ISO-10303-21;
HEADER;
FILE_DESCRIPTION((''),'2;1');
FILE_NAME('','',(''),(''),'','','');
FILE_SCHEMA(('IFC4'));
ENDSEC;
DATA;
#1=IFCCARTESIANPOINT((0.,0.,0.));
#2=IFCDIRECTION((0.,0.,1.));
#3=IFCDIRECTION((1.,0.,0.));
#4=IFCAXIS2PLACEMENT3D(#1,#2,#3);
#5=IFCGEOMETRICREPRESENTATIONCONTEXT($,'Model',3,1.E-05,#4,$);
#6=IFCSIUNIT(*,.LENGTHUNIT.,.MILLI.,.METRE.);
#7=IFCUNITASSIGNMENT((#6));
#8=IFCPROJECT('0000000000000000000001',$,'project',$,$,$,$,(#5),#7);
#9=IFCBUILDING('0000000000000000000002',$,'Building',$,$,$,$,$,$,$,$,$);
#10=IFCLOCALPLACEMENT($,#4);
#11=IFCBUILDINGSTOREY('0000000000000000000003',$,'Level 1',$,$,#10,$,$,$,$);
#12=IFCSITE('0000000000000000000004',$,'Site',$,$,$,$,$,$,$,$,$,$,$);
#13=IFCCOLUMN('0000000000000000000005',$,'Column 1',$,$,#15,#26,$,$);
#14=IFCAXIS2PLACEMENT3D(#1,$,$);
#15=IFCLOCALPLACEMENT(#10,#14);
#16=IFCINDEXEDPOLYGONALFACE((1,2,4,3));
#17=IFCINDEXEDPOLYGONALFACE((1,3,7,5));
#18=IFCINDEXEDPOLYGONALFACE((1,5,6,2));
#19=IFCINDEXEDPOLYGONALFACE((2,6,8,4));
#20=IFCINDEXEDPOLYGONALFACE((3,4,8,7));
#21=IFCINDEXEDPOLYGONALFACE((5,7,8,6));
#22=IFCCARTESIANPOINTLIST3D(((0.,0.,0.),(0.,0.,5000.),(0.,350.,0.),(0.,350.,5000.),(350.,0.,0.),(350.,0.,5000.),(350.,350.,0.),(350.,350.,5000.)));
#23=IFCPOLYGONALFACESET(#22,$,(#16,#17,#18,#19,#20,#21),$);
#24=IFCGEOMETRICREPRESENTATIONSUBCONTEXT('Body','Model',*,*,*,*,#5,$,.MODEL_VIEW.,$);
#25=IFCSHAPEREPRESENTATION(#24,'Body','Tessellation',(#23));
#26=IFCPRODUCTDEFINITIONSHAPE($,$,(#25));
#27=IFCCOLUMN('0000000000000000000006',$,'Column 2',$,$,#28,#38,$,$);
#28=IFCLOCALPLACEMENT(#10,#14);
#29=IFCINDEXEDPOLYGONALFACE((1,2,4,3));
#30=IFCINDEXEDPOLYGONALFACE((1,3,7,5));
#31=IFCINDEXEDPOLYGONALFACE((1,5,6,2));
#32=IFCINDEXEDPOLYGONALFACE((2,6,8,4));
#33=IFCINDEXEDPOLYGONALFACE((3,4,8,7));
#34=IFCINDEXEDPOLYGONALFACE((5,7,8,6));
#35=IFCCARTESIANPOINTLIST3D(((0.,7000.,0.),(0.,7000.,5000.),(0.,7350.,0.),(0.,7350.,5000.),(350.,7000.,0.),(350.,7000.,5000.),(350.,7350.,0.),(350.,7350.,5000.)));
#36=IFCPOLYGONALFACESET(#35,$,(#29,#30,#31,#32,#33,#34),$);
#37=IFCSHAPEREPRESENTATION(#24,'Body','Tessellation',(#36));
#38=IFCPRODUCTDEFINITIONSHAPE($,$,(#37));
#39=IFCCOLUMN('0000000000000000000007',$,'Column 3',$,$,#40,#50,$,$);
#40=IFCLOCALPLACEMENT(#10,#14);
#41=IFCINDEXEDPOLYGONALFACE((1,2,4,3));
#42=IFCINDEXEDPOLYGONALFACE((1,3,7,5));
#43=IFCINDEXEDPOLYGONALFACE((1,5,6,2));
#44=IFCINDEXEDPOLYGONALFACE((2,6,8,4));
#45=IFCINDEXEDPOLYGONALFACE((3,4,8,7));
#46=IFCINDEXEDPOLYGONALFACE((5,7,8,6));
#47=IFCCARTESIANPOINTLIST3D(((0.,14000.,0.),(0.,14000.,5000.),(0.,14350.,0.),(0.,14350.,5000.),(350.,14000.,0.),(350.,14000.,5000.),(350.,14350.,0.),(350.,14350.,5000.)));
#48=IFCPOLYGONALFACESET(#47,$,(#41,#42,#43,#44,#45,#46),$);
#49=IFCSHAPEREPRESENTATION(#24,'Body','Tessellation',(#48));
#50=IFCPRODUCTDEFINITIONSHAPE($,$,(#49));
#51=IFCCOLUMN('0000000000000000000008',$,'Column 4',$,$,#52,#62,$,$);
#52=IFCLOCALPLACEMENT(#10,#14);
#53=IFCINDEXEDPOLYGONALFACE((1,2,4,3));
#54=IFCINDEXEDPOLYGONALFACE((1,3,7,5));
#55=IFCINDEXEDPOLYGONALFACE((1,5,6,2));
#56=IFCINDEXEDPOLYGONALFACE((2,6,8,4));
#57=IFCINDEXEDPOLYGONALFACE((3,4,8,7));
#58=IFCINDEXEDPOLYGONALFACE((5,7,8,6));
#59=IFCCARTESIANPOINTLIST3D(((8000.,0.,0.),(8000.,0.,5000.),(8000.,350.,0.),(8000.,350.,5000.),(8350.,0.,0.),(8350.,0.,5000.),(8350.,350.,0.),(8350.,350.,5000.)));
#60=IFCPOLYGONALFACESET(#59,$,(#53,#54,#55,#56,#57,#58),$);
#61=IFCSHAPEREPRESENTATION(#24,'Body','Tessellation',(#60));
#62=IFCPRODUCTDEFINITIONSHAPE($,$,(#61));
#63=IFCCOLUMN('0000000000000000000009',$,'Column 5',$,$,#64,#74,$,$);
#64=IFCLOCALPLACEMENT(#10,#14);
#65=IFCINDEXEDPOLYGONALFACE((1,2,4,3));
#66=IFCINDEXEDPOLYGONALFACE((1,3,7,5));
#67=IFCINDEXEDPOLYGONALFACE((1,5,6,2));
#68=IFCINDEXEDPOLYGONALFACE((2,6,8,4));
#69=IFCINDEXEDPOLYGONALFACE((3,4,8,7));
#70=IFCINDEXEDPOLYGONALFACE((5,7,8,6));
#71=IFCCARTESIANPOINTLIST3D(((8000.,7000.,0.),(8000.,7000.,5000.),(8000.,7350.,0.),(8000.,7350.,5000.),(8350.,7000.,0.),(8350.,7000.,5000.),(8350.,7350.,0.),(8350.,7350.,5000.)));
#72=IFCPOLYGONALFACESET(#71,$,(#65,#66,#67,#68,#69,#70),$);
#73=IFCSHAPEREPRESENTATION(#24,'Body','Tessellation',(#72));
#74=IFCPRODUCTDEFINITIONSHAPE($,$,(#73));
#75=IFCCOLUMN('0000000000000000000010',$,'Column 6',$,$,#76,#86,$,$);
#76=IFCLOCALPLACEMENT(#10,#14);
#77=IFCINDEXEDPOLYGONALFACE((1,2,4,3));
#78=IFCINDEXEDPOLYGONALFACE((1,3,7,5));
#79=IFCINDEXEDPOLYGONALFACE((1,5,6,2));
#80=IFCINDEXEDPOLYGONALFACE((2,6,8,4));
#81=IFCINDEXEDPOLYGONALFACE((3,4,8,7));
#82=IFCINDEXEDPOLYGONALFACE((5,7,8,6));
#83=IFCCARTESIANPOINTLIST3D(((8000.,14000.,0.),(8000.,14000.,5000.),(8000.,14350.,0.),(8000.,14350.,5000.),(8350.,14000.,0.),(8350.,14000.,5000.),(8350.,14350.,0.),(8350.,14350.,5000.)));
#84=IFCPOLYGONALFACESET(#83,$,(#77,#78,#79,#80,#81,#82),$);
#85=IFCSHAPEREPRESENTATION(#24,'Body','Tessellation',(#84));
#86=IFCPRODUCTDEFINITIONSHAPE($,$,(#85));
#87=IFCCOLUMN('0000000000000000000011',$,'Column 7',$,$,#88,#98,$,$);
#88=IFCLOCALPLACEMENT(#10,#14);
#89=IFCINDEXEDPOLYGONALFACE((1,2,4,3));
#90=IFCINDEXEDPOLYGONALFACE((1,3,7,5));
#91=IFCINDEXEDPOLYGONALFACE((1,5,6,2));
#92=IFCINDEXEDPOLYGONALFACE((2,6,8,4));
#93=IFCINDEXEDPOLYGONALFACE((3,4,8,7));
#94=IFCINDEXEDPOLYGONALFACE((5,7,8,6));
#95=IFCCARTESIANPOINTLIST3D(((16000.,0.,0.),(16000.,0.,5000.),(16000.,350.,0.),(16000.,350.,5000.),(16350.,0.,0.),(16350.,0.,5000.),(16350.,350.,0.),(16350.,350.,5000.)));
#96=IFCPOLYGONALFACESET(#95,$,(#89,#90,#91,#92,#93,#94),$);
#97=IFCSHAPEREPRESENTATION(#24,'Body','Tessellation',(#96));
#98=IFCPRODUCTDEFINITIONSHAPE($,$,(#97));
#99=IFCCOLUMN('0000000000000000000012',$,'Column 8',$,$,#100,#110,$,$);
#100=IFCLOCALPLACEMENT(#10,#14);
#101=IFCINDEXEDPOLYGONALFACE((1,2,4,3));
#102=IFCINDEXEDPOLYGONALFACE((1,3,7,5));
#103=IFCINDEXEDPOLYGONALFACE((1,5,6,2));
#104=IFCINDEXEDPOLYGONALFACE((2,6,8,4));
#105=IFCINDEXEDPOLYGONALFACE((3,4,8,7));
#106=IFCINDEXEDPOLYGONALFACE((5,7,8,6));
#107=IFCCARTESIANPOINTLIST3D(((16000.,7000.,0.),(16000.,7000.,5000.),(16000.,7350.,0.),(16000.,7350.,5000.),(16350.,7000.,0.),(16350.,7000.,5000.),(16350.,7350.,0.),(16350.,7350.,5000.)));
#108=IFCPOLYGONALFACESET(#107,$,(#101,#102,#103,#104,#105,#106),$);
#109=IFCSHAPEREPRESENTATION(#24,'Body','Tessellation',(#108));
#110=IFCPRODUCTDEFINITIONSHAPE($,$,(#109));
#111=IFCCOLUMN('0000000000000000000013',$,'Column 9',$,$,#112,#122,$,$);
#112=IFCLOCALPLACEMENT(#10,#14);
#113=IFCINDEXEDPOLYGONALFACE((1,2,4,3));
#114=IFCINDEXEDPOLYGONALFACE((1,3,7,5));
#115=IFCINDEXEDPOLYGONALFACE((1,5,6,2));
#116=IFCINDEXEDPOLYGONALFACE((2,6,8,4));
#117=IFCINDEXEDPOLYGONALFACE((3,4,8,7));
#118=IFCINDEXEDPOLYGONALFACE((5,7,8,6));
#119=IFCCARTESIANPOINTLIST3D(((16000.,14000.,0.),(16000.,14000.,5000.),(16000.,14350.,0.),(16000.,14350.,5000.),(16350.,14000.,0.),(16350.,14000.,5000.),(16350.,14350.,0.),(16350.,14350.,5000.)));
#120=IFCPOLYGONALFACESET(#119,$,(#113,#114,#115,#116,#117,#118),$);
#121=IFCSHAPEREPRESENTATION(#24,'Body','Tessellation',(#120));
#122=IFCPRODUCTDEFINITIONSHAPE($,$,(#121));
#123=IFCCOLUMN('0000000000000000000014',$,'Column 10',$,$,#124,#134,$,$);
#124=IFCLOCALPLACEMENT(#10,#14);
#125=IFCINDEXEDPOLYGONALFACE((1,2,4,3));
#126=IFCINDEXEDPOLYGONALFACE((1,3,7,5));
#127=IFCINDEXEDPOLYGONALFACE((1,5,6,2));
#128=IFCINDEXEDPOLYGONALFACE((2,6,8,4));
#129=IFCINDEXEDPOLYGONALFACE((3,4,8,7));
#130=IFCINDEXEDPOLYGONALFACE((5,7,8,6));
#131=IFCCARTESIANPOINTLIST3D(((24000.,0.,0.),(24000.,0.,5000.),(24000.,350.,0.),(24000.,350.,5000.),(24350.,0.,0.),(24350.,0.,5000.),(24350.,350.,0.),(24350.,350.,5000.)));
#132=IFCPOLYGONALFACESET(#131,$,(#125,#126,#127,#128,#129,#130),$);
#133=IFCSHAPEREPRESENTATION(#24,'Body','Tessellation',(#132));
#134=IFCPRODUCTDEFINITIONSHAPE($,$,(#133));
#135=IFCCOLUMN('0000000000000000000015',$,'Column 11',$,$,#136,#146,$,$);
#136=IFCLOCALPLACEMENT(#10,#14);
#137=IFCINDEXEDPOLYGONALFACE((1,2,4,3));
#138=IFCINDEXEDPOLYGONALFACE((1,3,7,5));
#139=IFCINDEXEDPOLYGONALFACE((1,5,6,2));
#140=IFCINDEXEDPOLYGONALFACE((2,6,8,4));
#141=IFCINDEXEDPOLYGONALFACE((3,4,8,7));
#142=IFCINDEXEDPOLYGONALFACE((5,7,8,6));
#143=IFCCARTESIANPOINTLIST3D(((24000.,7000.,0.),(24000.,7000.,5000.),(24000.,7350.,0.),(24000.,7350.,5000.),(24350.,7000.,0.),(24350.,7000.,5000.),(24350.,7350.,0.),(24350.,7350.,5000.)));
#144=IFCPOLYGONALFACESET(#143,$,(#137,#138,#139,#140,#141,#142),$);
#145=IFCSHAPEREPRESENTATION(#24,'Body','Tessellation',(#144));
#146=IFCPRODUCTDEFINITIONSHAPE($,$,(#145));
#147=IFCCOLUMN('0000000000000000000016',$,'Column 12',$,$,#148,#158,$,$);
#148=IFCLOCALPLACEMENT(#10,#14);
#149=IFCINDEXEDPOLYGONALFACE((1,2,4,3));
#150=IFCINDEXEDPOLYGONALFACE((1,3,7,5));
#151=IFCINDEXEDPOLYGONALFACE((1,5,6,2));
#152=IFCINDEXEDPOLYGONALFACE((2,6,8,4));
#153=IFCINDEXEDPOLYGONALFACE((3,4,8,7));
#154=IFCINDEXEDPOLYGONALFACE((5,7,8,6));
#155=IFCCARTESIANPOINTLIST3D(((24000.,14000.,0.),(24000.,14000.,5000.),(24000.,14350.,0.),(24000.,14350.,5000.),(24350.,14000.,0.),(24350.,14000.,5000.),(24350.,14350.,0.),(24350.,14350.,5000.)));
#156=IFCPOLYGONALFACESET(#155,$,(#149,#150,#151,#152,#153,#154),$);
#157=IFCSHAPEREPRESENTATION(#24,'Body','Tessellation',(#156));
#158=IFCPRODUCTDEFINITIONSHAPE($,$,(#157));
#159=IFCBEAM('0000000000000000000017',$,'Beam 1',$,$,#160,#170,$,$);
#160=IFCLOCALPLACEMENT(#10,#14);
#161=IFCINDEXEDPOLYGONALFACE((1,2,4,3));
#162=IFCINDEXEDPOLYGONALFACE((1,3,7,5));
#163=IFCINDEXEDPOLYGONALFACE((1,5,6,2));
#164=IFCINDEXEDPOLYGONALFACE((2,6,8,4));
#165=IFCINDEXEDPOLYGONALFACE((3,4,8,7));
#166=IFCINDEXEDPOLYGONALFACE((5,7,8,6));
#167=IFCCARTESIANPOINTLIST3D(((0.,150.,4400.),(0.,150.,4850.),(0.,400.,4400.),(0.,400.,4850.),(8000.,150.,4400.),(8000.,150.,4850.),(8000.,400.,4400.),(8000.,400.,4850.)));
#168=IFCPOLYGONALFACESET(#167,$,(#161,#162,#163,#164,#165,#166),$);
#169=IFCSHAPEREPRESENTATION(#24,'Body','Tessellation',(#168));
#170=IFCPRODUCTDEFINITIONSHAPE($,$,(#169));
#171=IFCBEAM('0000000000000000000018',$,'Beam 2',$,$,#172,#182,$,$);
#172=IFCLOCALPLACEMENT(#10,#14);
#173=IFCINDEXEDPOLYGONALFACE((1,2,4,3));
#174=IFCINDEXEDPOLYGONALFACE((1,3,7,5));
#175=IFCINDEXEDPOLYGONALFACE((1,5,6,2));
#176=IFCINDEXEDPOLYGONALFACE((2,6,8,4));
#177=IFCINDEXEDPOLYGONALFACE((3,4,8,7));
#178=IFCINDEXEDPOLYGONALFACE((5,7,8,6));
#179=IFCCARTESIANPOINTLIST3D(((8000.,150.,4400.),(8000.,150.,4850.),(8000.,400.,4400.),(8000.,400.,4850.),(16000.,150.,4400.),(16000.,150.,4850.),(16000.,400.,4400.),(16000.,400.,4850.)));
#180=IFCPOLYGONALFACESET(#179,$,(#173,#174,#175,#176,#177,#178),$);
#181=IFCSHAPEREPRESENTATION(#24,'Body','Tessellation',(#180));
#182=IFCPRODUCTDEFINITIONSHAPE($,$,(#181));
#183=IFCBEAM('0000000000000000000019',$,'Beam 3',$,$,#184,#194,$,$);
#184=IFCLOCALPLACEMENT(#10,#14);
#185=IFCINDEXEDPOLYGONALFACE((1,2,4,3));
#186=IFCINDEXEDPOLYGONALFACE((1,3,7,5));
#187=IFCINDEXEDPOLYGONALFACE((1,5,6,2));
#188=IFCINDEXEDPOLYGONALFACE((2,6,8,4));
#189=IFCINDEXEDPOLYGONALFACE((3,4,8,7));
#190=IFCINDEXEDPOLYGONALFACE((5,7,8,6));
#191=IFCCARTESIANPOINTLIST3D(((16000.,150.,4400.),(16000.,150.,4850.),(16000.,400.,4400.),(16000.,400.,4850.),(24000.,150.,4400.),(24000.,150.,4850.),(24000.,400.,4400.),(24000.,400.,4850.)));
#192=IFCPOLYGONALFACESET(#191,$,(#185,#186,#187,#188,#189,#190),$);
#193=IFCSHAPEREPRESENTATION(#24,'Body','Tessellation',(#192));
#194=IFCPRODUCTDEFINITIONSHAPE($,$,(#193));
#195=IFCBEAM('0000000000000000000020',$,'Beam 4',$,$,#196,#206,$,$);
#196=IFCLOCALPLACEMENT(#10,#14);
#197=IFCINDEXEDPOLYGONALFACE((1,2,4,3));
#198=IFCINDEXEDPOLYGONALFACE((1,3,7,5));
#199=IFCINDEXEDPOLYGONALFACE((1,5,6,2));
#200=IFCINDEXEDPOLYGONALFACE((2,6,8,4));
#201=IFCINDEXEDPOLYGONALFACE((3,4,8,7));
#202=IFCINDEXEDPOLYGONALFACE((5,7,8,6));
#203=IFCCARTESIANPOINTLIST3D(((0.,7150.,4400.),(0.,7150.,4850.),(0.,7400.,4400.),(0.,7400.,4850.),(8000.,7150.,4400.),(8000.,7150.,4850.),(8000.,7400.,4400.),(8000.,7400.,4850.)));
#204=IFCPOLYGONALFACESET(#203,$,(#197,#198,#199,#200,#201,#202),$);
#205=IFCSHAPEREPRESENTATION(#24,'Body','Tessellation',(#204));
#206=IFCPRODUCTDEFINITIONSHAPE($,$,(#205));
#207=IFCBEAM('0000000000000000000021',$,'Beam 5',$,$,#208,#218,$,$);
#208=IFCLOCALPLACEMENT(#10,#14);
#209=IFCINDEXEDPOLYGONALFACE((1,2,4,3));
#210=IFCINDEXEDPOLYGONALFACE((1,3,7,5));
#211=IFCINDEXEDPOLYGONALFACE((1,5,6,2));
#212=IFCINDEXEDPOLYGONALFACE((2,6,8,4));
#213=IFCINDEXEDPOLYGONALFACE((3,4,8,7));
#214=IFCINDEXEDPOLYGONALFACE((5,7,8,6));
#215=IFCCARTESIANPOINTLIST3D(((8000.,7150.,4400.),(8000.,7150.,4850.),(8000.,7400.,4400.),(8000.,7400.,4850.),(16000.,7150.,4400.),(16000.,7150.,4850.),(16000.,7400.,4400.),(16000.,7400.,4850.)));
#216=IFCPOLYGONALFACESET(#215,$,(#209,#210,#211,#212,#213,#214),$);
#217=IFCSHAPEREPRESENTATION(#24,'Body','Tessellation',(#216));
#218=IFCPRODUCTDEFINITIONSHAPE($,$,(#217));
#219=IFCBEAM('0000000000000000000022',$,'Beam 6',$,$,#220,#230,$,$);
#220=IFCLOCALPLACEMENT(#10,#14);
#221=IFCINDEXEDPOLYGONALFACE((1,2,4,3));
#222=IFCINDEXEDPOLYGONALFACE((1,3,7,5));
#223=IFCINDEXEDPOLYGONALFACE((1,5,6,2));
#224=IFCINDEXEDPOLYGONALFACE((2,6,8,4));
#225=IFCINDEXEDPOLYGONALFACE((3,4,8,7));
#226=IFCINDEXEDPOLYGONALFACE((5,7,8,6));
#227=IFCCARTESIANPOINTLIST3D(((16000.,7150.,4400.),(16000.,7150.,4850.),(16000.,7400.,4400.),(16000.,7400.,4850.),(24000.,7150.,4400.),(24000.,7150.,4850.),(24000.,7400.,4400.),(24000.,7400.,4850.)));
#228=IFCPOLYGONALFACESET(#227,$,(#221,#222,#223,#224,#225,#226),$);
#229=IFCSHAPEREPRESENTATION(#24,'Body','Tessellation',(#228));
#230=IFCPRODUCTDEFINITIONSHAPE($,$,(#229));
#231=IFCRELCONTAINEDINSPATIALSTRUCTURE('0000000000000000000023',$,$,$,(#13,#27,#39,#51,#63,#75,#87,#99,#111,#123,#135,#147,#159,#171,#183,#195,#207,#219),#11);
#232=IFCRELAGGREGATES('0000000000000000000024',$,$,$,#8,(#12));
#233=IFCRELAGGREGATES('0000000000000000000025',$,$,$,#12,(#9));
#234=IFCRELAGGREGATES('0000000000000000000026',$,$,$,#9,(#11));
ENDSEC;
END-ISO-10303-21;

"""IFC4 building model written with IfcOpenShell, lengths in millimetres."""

from ifc_helpers import new_model, si_unit, frame, origin_with_axes, place, context, subcontext, project, spatial, indexed_curve, outline, extrude, element, save


model = new_model("IFC4")

# Units and contexts
model_context = context("Model", 3, precision=1e-05, world=origin_with_axes())
body_context = subcontext(model_context, "Body", "Model", "MODEL_VIEW")
ifc_project = project(units=[si_unit("LENGTHUNIT", "METRE", prefix="MILLI")], contexts=[model_context])

# Site, building, storey
site = spatial("IfcSite", under=ifc_project, Name="Site")
building = spatial("IfcBuilding", under=site, Name="Building")
storey_placement = place(None, origin_with_axes())
storey = spatial("IfcBuildingStorey", under=building, at=storey_placement, Name="Level 1")

# Columns
column_1_placement = place(storey_placement, origin_with_axes())
element("IfcColumn", 1, at=column_1_placement, inside=storey, Name="Column 1", context=body_context, shape_type="SweptSolid", body=[
    extrude(outline(indexed_curve([(0.0, 0.0), (350.0, 0.0), (350.0, 350.0), (0.0, 350.0), (0.0, 0.0)])), None, (0.0, 0.0, 1.0), 5000.0),
])
column_2_placement = place(storey_placement, origin_with_axes())
element("IfcColumn", 2, at=column_2_placement, inside=storey, Name="Column 2", context=body_context, shape_type="SweptSolid", body=[
    extrude(outline(indexed_curve([(0.0, 7000.0), (350.0, 7000.0), (350.0, 7350.0), (0.0, 7350.0), (0.0, 7000.0)])), None, (0.0, 0.0, 1.0), 5000.0),
])
column_3_placement = place(storey_placement, origin_with_axes())
element("IfcColumn", 3, at=column_3_placement, inside=storey, Name="Column 3", context=body_context, shape_type="SweptSolid", body=[
    extrude(outline(indexed_curve([(0.0, 14000.0), (350.0, 14000.0), (350.0, 14350.0), (0.0, 14350.0), (0.0, 14000.0)])), None, (0.0, 0.0, 1.0), 5000.0),
])
column_4_placement = place(storey_placement, origin_with_axes())
element("IfcColumn", 4, at=column_4_placement, inside=storey, Name="Column 4", context=body_context, shape_type="SweptSolid", body=[
    extrude(outline(indexed_curve([(8000.0, 0.0), (8350.0, 0.0), (8350.0, 350.0), (8000.0, 350.0), (8000.0, 0.0)])), None, (0.0, 0.0, 1.0), 5000.0),
])
column_5_placement = place(storey_placement, origin_with_axes())
element("IfcColumn", 5, at=column_5_placement, inside=storey, Name="Column 5", context=body_context, shape_type="SweptSolid", body=[
    extrude(outline(indexed_curve([(8000.0, 7000.0), (8350.0, 7000.0), (8350.0, 7350.0), (8000.0, 7350.0), (8000.0, 7000.0)])), None, (0.0, 0.0, 1.0), 5000.0),
])
column_6_placement = place(storey_placement, origin_with_axes())
element("IfcColumn", 6, at=column_6_placement, inside=storey, Name="Column 6", context=body_context, shape_type="SweptSolid", body=[
    extrude(outline(indexed_curve([(8000.0, 14000.0), (8350.0, 14000.0), (8350.0, 14350.0), (8000.0, 14350.0), (8000.0, 14000.0)])), None, (0.0, 0.0, 1.0), 5000.0),
])
column_7_placement = place(storey_placement, origin_with_axes())
element("IfcColumn", 7, at=column_7_placement, inside=storey, Name="Column 7", context=body_context, shape_type="SweptSolid", body=[
    extrude(outline(indexed_curve([(16000.0, 0.0), (16350.0, 0.0), (16350.0, 350.0), (16000.0, 350.0), (16000.0, 0.0)])), None, (0.0, 0.0, 1.0), 5000.0),
])
column_8_placement = place(storey_placement, origin_with_axes())
element("IfcColumn", 8, at=column_8_placement, inside=storey, Name="Column 8", context=body_context, shape_type="SweptSolid", body=[
    extrude(outline(indexed_curve([(16000.0, 7000.0), (16350.0, 7000.0), (16350.0, 7350.0), (16000.0, 7350.0), (16000.0, 7000.0)])), None, (0.0, 0.0, 1.0), 5000.0),
])
column_9_placement = place(storey_placement, origin_with_axes())
element("IfcColumn", 9, at=column_9_placement, inside=storey, Name="Column 9", context=body_context, shape_type="SweptSolid", body=[
    extrude(outline(indexed_curve([(16000.0, 14000.0), (16350.0, 14000.0), (16350.0, 14350.0), (16000.0, 14350.0), (16000.0, 14000.0)])), None, (0.0, 0.0, 1.0), 5000.0),
])
column_10_placement = place(storey_placement, origin_with_axes())
element("IfcColumn", 10, at=column_10_placement, inside=storey, Name="Column 10", context=body_context, shape_type="SweptSolid", body=[
    extrude(outline(indexed_curve([(24000.0, 0.0), (24350.0, 0.0), (24350.0, 350.0), (24000.0, 350.0), (24000.0, 0.0)])), None, (0.0, 0.0, 1.0), 5000.0),
])
column_11_placement = place(storey_placement, origin_with_axes())
element("IfcColumn", 11, at=column_11_placement, inside=storey, Name="Column 11", context=body_context, shape_type="SweptSolid", body=[
    extrude(outline(indexed_curve([(24000.0, 7000.0), (24350.0, 7000.0), (24350.0, 7350.0), (24000.0, 7350.0), (24000.0, 7000.0)])), None, (0.0, 0.0, 1.0), 5000.0),
])
column_12_placement = place(storey_placement, origin_with_axes())
element("IfcColumn", 12, at=column_12_placement, inside=storey, Name="Column 12", context=body_context, shape_type="SweptSolid", body=[
    extrude(outline(indexed_curve([(24000.0, 14000.0), (24350.0, 14000.0), (24350.0, 14350.0), (24000.0, 14350.0), (24000.0, 14000.0)])), None, (0.0, 0.0, 1.0), 5000.0),
])

# Beams
for number, where, z_axis, x_axis, name in (
    (13, (0.0, 150.0, 4400.0), (0.0, 0.0, 1.0), (1.0, 0.0, 0.0), "Beam 1"),
    (14, (8000.0, 150.0, 4400.0), (0.0, 0.0, 1.0), (1.0, 0.0, 0.0), "Beam 2"),
    (15, (16000.0, 150.0, 4400.0), (0.0, 0.0, 1.0), (1.0, 0.0, 0.0), "Beam 3"),
    (16, (0.0, 7150.0, 4400.0), (0.0, 0.0, 1.0), (1.0, 0.0, 0.0), "Beam 4"),
    (17, (8000.0, 7150.0, 4400.0), (0.0, 0.0, 1.0), (1.0, 0.0, 0.0), "Beam 5"),
    (18, (16000.0, 7150.0, 4400.0), (0.0, 0.0, 1.0), (1.0, 0.0, 0.0), "Beam 6"),
):
    element("IfcBeam", number, at=place(storey_placement, frame(where, z_axis=z_axis, x_axis=x_axis)), inside=storey, Name=name, context=body_context, shape_type="SweptSolid", body=[
        extrude(outline(indexed_curve([(0.0, 0.0), (0.0, 250.0), (8000.0, 250.0), (8000.0, 0.0), (0.0, 0.0)], self_intersect=False)), origin_with_axes(), (0.0, 0.0, 1.0), 450.0),
    ])

save(model, "model.ifc")
